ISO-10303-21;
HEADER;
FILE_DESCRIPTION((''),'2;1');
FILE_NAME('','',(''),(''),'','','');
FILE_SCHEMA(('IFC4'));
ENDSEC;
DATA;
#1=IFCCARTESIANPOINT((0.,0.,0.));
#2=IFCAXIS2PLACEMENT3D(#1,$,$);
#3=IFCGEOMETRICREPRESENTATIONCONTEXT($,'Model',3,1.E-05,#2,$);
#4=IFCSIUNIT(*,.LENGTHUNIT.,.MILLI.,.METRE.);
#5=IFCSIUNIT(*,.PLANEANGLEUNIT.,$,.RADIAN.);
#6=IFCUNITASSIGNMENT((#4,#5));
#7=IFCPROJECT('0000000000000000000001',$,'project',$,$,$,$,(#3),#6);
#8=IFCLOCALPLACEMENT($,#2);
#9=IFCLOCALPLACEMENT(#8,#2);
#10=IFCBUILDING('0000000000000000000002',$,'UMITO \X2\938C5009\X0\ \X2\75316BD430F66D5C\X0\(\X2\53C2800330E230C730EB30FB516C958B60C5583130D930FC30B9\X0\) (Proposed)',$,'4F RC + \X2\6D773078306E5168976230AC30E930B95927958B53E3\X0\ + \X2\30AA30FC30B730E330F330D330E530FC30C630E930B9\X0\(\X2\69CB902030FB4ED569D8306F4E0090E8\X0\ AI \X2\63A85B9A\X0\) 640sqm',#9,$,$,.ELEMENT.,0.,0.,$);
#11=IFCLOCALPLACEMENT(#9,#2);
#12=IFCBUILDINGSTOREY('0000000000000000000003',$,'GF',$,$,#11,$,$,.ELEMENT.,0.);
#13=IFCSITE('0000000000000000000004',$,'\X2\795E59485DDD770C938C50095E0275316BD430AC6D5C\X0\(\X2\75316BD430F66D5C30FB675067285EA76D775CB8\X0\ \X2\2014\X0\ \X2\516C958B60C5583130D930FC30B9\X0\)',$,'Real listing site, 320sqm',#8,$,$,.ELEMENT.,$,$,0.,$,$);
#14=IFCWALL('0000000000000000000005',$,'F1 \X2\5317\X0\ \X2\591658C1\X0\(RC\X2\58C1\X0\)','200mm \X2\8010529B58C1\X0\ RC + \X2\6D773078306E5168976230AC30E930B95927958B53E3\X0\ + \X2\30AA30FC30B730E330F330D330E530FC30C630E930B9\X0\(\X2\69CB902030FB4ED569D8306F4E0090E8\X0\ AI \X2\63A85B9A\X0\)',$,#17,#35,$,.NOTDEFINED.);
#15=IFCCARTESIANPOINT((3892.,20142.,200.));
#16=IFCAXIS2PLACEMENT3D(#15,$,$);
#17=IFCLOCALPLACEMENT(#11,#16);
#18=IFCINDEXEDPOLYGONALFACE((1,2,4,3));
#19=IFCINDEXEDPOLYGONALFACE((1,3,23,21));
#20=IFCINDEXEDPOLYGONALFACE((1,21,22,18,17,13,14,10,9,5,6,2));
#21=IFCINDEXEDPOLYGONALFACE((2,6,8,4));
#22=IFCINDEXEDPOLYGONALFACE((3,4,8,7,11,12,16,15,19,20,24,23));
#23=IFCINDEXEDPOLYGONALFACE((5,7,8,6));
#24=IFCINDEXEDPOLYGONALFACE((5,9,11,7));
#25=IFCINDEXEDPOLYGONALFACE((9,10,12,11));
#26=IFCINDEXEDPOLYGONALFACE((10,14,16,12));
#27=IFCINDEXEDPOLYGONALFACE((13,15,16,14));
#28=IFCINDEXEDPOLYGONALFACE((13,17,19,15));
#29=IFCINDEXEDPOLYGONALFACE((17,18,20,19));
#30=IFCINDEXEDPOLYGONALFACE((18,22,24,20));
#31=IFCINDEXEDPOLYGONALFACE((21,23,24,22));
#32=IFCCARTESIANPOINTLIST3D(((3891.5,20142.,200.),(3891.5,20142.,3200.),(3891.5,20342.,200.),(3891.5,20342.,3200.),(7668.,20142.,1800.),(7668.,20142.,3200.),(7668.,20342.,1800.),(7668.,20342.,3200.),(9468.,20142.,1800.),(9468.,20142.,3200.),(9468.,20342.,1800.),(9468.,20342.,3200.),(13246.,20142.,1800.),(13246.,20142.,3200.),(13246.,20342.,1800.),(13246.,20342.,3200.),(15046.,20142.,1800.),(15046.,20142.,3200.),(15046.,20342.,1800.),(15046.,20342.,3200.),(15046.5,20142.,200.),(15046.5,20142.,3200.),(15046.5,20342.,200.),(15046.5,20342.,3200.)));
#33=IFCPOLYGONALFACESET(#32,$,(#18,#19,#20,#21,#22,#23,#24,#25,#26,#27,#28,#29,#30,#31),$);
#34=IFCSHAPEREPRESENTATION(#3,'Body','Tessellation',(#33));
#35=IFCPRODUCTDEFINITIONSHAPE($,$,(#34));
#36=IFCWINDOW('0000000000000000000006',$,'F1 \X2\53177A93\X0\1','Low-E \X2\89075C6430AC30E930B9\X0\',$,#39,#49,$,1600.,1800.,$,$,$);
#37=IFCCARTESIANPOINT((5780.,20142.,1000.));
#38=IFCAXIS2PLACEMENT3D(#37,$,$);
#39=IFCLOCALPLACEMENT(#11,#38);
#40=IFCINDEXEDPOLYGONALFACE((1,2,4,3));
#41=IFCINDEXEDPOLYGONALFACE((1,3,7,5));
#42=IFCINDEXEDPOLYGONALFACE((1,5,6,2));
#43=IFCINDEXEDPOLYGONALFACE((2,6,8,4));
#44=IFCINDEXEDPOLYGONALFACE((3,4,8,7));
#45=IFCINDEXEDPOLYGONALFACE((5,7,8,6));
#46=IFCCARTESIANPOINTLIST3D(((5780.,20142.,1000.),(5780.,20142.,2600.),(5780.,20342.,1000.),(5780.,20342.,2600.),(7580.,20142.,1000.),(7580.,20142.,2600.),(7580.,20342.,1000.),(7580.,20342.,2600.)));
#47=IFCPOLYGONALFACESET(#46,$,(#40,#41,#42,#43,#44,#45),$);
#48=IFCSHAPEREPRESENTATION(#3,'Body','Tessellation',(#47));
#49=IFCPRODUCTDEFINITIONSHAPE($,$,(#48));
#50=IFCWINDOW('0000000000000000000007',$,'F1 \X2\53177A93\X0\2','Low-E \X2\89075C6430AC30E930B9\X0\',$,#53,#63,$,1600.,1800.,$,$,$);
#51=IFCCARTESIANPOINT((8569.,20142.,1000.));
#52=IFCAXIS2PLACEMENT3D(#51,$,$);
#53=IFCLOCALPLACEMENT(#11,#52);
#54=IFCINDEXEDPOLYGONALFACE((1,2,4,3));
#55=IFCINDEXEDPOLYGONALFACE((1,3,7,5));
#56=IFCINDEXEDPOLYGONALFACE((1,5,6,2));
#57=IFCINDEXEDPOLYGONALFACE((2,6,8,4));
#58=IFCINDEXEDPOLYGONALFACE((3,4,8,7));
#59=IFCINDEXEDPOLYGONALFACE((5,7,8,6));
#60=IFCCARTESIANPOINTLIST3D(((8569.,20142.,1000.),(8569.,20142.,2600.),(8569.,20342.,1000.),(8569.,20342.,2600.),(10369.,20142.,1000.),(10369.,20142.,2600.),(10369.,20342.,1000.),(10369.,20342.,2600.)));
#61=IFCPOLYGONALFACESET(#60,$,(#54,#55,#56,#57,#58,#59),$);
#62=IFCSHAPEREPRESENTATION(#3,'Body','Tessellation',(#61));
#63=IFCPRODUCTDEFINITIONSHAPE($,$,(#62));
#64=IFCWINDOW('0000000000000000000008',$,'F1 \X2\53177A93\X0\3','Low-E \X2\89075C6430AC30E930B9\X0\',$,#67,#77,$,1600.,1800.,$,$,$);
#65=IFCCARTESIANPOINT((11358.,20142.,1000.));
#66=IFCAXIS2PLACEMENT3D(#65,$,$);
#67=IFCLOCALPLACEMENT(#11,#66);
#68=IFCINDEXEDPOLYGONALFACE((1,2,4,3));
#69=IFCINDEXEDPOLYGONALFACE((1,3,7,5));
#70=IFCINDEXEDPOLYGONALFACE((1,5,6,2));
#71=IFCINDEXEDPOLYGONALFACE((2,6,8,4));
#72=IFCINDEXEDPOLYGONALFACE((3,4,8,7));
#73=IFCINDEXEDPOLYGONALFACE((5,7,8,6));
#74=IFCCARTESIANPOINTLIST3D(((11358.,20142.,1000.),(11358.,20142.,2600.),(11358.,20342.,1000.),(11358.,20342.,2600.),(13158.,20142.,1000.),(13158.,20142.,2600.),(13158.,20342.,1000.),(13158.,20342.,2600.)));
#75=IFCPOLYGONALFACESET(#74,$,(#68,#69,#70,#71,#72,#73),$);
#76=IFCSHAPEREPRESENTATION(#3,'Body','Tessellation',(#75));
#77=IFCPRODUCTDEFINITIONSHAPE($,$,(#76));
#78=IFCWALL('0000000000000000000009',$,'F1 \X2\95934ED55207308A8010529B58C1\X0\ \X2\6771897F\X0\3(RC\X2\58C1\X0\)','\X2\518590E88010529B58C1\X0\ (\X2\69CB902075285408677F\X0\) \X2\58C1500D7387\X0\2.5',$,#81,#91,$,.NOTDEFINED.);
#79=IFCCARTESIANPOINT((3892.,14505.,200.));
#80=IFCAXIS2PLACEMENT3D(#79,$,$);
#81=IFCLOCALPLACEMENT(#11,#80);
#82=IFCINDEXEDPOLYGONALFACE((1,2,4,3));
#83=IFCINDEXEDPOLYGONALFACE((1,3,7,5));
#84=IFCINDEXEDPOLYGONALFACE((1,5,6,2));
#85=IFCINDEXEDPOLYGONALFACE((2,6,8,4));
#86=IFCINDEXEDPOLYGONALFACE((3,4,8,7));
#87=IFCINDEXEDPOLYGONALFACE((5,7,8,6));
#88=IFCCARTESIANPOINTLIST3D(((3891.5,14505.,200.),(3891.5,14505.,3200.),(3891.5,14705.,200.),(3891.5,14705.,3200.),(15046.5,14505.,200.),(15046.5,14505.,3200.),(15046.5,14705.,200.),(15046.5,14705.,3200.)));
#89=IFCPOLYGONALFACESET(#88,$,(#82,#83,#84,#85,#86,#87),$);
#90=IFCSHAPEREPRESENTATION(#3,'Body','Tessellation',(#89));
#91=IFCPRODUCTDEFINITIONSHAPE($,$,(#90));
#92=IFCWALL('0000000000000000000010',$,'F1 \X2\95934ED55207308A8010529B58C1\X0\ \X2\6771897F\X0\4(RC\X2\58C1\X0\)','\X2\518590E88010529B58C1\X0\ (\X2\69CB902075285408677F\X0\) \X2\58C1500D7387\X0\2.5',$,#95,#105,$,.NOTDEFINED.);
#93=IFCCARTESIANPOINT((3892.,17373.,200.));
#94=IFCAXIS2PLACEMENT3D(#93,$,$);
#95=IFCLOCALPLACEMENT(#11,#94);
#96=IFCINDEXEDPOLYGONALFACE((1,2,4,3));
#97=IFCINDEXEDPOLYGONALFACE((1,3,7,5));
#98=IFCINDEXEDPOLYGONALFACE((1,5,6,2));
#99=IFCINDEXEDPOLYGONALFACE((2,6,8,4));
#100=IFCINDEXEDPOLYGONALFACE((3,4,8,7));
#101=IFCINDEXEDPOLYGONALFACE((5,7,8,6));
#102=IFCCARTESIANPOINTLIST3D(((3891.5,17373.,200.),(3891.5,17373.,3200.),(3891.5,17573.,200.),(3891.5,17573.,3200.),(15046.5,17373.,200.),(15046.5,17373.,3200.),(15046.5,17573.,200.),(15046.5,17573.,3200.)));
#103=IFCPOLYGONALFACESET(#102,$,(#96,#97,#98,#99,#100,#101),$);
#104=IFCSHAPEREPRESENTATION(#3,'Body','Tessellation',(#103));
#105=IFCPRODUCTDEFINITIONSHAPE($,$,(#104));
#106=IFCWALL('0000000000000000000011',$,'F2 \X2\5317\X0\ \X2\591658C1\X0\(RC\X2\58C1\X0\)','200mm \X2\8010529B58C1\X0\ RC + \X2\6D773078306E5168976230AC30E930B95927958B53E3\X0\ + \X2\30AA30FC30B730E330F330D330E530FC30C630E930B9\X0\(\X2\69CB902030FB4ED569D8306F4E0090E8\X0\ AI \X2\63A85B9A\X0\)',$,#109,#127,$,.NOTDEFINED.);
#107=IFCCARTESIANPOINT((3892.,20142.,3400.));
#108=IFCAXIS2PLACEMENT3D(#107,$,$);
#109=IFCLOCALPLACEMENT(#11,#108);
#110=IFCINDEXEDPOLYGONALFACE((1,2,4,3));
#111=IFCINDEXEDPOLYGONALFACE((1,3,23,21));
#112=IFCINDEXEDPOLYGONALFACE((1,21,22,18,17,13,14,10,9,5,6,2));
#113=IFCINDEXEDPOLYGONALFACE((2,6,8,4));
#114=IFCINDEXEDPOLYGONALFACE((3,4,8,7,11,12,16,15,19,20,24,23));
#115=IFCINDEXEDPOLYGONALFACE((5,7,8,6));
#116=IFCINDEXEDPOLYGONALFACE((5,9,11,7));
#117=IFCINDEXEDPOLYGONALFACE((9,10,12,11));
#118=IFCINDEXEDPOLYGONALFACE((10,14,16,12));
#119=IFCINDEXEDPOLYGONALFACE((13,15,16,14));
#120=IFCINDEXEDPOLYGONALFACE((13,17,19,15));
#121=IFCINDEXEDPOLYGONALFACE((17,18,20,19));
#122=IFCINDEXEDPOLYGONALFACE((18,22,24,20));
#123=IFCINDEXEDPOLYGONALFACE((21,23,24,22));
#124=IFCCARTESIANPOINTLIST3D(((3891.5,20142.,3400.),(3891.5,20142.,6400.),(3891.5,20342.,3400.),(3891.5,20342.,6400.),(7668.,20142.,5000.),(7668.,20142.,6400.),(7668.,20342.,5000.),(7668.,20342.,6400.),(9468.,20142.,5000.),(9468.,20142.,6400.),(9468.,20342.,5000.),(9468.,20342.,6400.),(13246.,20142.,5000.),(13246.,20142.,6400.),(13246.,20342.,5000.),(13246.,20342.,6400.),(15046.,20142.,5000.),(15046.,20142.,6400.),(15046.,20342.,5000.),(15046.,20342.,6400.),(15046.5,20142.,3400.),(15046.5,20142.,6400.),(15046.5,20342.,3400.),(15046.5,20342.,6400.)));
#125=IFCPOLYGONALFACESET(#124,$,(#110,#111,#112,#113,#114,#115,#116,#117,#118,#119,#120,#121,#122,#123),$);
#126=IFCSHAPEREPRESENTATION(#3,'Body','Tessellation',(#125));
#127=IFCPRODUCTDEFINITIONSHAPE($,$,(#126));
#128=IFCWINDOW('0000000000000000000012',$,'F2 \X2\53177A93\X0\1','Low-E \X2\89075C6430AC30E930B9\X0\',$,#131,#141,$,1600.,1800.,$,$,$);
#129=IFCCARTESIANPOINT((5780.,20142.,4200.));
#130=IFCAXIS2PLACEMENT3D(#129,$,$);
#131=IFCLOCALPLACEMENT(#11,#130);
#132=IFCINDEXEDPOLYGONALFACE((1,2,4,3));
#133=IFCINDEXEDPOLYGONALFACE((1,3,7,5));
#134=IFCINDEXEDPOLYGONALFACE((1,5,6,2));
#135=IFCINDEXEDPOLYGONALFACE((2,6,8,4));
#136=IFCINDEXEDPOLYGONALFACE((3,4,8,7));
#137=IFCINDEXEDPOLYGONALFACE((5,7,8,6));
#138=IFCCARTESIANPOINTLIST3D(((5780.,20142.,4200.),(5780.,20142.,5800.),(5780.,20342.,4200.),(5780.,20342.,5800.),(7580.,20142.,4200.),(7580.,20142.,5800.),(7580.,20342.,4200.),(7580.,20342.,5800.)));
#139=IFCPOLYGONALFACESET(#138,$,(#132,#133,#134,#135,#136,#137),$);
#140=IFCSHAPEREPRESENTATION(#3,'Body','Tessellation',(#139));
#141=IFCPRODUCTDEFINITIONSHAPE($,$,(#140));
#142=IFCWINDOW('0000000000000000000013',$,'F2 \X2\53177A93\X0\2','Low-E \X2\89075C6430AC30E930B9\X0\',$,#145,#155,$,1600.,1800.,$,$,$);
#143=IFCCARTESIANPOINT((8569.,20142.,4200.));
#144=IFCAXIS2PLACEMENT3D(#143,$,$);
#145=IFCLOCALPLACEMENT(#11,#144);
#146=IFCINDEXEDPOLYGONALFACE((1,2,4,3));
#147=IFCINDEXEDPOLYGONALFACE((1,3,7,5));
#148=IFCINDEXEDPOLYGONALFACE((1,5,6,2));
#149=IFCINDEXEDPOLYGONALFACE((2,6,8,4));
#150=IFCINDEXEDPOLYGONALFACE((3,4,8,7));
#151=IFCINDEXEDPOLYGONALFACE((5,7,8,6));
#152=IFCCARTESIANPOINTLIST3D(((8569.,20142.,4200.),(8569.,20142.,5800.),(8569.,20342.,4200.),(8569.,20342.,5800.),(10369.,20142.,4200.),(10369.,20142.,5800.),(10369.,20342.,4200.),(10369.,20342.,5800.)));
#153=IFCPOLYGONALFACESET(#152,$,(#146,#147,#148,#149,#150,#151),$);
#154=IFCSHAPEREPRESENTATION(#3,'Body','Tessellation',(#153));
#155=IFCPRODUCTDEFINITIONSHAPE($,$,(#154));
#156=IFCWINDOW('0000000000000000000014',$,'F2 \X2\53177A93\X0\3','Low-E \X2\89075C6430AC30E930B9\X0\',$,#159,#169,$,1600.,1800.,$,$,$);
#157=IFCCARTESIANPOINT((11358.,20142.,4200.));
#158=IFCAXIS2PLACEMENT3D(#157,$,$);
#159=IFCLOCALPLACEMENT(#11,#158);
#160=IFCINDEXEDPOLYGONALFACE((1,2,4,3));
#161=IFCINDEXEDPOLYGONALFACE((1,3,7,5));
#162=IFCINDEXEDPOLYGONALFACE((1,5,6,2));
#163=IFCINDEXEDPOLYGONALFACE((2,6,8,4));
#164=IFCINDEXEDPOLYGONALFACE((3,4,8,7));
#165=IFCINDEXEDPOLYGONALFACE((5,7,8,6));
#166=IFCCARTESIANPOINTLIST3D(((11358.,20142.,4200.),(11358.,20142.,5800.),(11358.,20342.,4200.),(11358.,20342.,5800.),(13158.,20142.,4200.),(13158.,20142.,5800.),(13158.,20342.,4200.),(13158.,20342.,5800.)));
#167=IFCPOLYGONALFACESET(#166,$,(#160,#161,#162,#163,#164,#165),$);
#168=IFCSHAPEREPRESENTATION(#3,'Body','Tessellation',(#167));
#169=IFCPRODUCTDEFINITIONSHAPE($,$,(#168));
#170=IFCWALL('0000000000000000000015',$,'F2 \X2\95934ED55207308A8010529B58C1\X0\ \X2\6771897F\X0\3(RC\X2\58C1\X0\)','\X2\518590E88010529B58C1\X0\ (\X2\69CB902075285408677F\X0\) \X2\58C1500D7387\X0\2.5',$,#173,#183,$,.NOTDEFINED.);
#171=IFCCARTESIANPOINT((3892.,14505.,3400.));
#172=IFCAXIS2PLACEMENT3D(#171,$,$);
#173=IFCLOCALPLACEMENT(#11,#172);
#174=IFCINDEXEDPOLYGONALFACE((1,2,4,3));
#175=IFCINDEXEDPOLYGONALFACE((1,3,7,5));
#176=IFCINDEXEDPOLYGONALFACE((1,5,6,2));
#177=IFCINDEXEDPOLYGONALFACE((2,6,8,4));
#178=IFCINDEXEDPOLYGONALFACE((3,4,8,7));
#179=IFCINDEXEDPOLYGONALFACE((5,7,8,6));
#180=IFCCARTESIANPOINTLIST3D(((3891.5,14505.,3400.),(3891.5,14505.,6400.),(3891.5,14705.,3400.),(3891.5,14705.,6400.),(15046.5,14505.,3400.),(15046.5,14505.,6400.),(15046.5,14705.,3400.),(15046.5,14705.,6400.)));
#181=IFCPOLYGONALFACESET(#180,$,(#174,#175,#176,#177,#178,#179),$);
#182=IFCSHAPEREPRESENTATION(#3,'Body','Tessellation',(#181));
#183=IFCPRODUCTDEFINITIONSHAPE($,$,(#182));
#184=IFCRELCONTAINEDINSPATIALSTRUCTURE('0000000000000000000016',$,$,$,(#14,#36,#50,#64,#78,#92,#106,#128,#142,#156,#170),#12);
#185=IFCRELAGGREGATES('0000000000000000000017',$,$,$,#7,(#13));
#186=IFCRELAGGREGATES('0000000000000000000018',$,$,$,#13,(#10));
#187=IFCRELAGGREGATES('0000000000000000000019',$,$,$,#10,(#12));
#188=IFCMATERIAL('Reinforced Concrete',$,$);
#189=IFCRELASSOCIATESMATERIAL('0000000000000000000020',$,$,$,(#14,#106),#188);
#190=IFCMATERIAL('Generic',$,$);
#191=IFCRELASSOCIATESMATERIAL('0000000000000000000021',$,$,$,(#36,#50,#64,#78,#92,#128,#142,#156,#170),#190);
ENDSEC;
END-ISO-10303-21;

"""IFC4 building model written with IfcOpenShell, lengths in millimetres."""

from ifc_helpers import new_model, si_unit, frame, frame_2d, origin, place, context, project, spatial, rectangle, extrude, material, element, fill, save


model = new_model("IFC4")

# Units and contexts
model_context = context("Model", 3, precision=1e-05, world=origin())
ifc_project = project(units=[si_unit("LENGTHUNIT", "METRE", prefix="MILLI"), si_unit("PLANEANGLEUNIT", "RADIAN")], contexts=[model_context])

# Site, building, storey
site_placement = place(None, origin())
site = spatial("IfcSite", under=ifc_project, at=site_placement, Name="神奈川県鎌倉市由比ガ浜(由比ヶ浜・材木座海岸 — 公開情報ベース)", ObjectType="Real listing site, 320sqm", CompositionType="ELEMENT", RefElevation=0.0)
building_placement = place(site_placement, origin())
building = spatial("IfcBuilding", under=site, at=building_placement, Name="UMITO 鎌倉 由比ヶ浜(参考モデル・公開情報ベース) (Proposed)", ObjectType="4F RC + 海への全面ガラス大開口 + オーシャンビューテラス(構造・仕様は一部 AI 推定) 640sqm", CompositionType="ELEMENT", ElevationOfRefHeight=0.0, ElevationOfTerrain=0.0)
storey_placement = place(building_placement, origin())
storey = spatial("IfcBuildingStorey", under=building, at=storey_placement, Name="GF", CompositionType="ELEMENT", Elevation=0.0)

# Wall, openings, windows
ifc_material_1 = material(Name="Reinforced Concrete")
wall_1_placement = place(storey_placement, frame((3892.0, 20142.0, 200.0)))
wall_1 = element("IfcWall", 1, at=wall_1_placement, inside=storey, material=ifc_material_1, Name="F1 北 外壁(RC壁)", Description="200mm 耐力壁 RC + 海への全面ガラス大開口 + オーシャンビューテラス(構造・仕様は一部 AI 推定)", PredefinedType="NOTDEFINED", context=model_context, shape_type="SweptSolid", body=[
    extrude(rectangle(XDim=11155.0, YDim=200.0, at=frame_2d((5577.0, 100.0))), frame((3892.0, 20142.0, 200.0)), (0.0, 0.0, 1.0), 3000.0),
])
opening_1_placement = place(storey_placement, frame((5780.0, 20142.0, 1000.0)))
opening_1 = element("IfcOpeningElement", 2, at=opening_1_placement, cuts=wall_1, PredefinedType="NOTDEFINED", context=model_context, shape_type="SweptSolid", body=[
    extrude(rectangle(XDim=1800.0, YDim=200.0, at=frame_2d((900.0, 100.0))), frame((5780.0, 20142.0, 1000.0)), (0.0, 0.0, 1.0), 1600.0),
])
opening_2_placement = place(storey_placement, frame((8569.0, 20142.0, 1000.0)))
opening_2 = element("IfcOpeningElement", 3, at=opening_2_placement, cuts=wall_1, PredefinedType="NOTDEFINED", context=model_context, shape_type="SweptSolid", body=[
    extrude(rectangle(XDim=1800.0, YDim=200.0, at=frame_2d((900.0, 100.0))), frame((8569.0, 20142.0, 1000.0)), (0.0, 0.0, 1.0), 1600.0),
])
opening_3_placement = place(storey_placement, frame((11358.0, 20142.0, 1000.0)))
opening_3 = element("IfcOpeningElement", 4, at=opening_3_placement, cuts=wall_1, PredefinedType="NOTDEFINED", context=model_context, shape_type="SweptSolid", body=[
    extrude(rectangle(XDim=1800.0, YDim=200.0, at=frame_2d((900.0, 100.0))), frame((11358.0, 20142.0, 1000.0)), (0.0, 0.0, 1.0), 1600.0),
])
ifc_material_2 = material(Name="Generic")
window_1_placement = place(storey_placement, frame((5780.0, 20142.0, 1000.0)))
window_1 = element("IfcWindow", 5, at=window_1_placement, inside=storey, material=ifc_material_2, Name="F1 北窓1", Description="Low-E 複層ガラス", OverallHeight=1600.0, OverallWidth=1800.0, context=model_context, shape_type="SweptSolid", body=[
    extrude(rectangle(XDim=1800.0, YDim=200.0, at=frame_2d((900.0, 100.0))), frame((5780.0, 20142.0, 1000.0)), (0.0, 0.0, 1.0), 1600.0),
])
fill(opening_1, window_1)
window_2_placement = place(storey_placement, frame((8569.0, 20142.0, 1000.0)))
window_2 = element("IfcWindow", 6, at=window_2_placement, inside=storey, material=ifc_material_2, Name="F1 北窓2", Description="Low-E 複層ガラス", OverallHeight=1600.0, OverallWidth=1800.0, context=model_context, shape_type="SweptSolid", body=[
    extrude(rectangle(XDim=1800.0, YDim=200.0, at=frame_2d((900.0, 100.0))), frame((8569.0, 20142.0, 1000.0)), (0.0, 0.0, 1.0), 1600.0),
])
fill(opening_2, window_2)
window_3_placement = place(storey_placement, frame((11358.0, 20142.0, 1000.0)))
window_3 = element("IfcWindow", 7, at=window_3_placement, inside=storey, material=ifc_material_2, Name="F1 北窓3", Description="Low-E 複層ガラス", OverallHeight=1600.0, OverallWidth=1800.0, context=model_context, shape_type="SweptSolid", body=[
    extrude(rectangle(XDim=1800.0, YDim=200.0, at=frame_2d((900.0, 100.0))), frame((11358.0, 20142.0, 1000.0)), (0.0, 0.0, 1.0), 1600.0),
])
fill(opening_3, window_3)

# Walls
wall_2_placement = place(storey_placement, frame((3892.0, 14505.0, 200.0)))
element("IfcWall", 8, at=wall_2_placement, inside=storey, material=ifc_material_2, Name="F1 間仕切り耐力壁 東西3(RC壁)", Description="内部耐力壁 (構造用合板) 壁倍率2.5", PredefinedType="NOTDEFINED", context=model_context, shape_type="SweptSolid", body=[
    extrude(rectangle(XDim=11155.0, YDim=200.0, at=frame_2d((5577.0, 100.0))), frame((3892.0, 14505.0, 200.0)), (0.0, 0.0, 1.0), 3000.0),
])
wall_3_placement = place(storey_placement, frame((3892.0, 17373.0, 200.0)))
element("IfcWall", 9, at=wall_3_placement, inside=storey, material=ifc_material_2, Name="F1 間仕切り耐力壁 東西4(RC壁)", Description="内部耐力壁 (構造用合板) 壁倍率2.5", PredefinedType="NOTDEFINED", context=model_context, shape_type="SweptSolid", body=[
    extrude(rectangle(XDim=11155.0, YDim=200.0, at=frame_2d((5577.0, 100.0))), frame((3892.0, 17373.0, 200.0)), (0.0, 0.0, 1.0), 3000.0),
])

# Wall, openings, windows
wall_4_placement = place(storey_placement, frame((3892.0, 20142.0, 3400.0)))
wall_4 = element("IfcWall", 10, at=wall_4_placement, inside=storey, material=ifc_material_1, Name="F2 北 外壁(RC壁)", Description="200mm 耐力壁 RC + 海への全面ガラス大開口 + オーシャンビューテラス(構造・仕様は一部 AI 推定)", PredefinedType="NOTDEFINED", context=model_context, shape_type="SweptSolid", body=[
    extrude(rectangle(XDim=11155.0, YDim=200.0, at=frame_2d((5577.0, 100.0))), frame((3892.0, 20142.0, 3400.0)), (0.0, 0.0, 1.0), 3000.0),
])
opening_4_placement = place(storey_placement, frame((5780.0, 20142.0, 4200.0)))
opening_4 = element("IfcOpeningElement", 11, at=opening_4_placement, cuts=wall_4, PredefinedType="NOTDEFINED", context=model_context, shape_type="SweptSolid", body=[
    extrude(rectangle(XDim=1800.0, YDim=200.0, at=frame_2d((900.0, 100.0))), frame((5780.0, 20142.0, 4200.0)), (0.0, 0.0, 1.0), 1600.0),
])
opening_5_placement = place(storey_placement, frame((8569.0, 20142.0, 4200.0)))
opening_5 = element("IfcOpeningElement", 12, at=opening_5_placement, cuts=wall_4, PredefinedType="NOTDEFINED", context=model_context, shape_type="SweptSolid", body=[
    extrude(rectangle(XDim=1800.0, YDim=200.0, at=frame_2d((900.0, 100.0))), frame((8569.0, 20142.0, 4200.0)), (0.0, 0.0, 1.0), 1600.0),
])
opening_6_placement = place(storey_placement, frame((11358.0, 20142.0, 4200.0)))
opening_6 = element("IfcOpeningElement", 13, at=opening_6_placement, cuts=wall_4, PredefinedType="NOTDEFINED", context=model_context, shape_type="SweptSolid", body=[
    extrude(rectangle(XDim=1800.0, YDim=200.0, at=frame_2d((900.0, 100.0))), frame((11358.0, 20142.0, 4200.0)), (0.0, 0.0, 1.0), 1600.0),
])
window_4_placement = place(storey_placement, frame((5780.0, 20142.0, 4200.0)))
window_4 = element("IfcWindow", 14, at=window_4_placement, inside=storey, material=ifc_material_2, Name="F2 北窓1", Description="Low-E 複層ガラス", OverallHeight=1600.0, OverallWidth=1800.0, context=model_context, shape_type="SweptSolid", body=[
    extrude(rectangle(XDim=1800.0, YDim=200.0, at=frame_2d((900.0, 100.0))), frame((5780.0, 20142.0, 4200.0)), (0.0, 0.0, 1.0), 1600.0),
])
fill(opening_4, window_4)
window_5_placement = place(storey_placement, frame((8569.0, 20142.0, 4200.0)))
window_5 = element("IfcWindow", 15, at=window_5_placement, inside=storey, material=ifc_material_2, Name="F2 北窓2", Description="Low-E 複層ガラス", OverallHeight=1600.0, OverallWidth=1800.0, context=model_context, shape_type="SweptSolid", body=[
    extrude(rectangle(XDim=1800.0, YDim=200.0, at=frame_2d((900.0, 100.0))), frame((8569.0, 20142.0, 4200.0)), (0.0, 0.0, 1.0), 1600.0),
])
fill(opening_5, window_5)
window_6_placement = place(storey_placement, frame((11358.0, 20142.0, 4200.0)))
window_6 = element("IfcWindow", 16, at=window_6_placement, inside=storey, material=ifc_material_2, Name="F2 北窓3", Description="Low-E 複層ガラス", OverallHeight=1600.0, OverallWidth=1800.0, context=model_context, shape_type="SweptSolid", body=[
    extrude(rectangle(XDim=1800.0, YDim=200.0, at=frame_2d((900.0, 100.0))), frame((11358.0, 20142.0, 4200.0)), (0.0, 0.0, 1.0), 1600.0),
])
fill(opening_6, window_6)

# Wall
wall_5_placement = place(storey_placement, frame((3892.0, 14505.0, 3400.0)))
element("IfcWall", 17, at=wall_5_placement, inside=storey, material=ifc_material_2, Name="F2 間仕切り耐力壁 東西3(RC壁)", Description="内部耐力壁 (構造用合板) 壁倍率2.5", PredefinedType="NOTDEFINED", context=model_context, shape_type="SweptSolid", body=[
    extrude(rectangle(XDim=11155.0, YDim=200.0, at=frame_2d((5577.0, 100.0))), frame((3892.0, 14505.0, 3400.0)), (0.0, 0.0, 1.0), 3000.0),
])

save(model, "model.ifc")
